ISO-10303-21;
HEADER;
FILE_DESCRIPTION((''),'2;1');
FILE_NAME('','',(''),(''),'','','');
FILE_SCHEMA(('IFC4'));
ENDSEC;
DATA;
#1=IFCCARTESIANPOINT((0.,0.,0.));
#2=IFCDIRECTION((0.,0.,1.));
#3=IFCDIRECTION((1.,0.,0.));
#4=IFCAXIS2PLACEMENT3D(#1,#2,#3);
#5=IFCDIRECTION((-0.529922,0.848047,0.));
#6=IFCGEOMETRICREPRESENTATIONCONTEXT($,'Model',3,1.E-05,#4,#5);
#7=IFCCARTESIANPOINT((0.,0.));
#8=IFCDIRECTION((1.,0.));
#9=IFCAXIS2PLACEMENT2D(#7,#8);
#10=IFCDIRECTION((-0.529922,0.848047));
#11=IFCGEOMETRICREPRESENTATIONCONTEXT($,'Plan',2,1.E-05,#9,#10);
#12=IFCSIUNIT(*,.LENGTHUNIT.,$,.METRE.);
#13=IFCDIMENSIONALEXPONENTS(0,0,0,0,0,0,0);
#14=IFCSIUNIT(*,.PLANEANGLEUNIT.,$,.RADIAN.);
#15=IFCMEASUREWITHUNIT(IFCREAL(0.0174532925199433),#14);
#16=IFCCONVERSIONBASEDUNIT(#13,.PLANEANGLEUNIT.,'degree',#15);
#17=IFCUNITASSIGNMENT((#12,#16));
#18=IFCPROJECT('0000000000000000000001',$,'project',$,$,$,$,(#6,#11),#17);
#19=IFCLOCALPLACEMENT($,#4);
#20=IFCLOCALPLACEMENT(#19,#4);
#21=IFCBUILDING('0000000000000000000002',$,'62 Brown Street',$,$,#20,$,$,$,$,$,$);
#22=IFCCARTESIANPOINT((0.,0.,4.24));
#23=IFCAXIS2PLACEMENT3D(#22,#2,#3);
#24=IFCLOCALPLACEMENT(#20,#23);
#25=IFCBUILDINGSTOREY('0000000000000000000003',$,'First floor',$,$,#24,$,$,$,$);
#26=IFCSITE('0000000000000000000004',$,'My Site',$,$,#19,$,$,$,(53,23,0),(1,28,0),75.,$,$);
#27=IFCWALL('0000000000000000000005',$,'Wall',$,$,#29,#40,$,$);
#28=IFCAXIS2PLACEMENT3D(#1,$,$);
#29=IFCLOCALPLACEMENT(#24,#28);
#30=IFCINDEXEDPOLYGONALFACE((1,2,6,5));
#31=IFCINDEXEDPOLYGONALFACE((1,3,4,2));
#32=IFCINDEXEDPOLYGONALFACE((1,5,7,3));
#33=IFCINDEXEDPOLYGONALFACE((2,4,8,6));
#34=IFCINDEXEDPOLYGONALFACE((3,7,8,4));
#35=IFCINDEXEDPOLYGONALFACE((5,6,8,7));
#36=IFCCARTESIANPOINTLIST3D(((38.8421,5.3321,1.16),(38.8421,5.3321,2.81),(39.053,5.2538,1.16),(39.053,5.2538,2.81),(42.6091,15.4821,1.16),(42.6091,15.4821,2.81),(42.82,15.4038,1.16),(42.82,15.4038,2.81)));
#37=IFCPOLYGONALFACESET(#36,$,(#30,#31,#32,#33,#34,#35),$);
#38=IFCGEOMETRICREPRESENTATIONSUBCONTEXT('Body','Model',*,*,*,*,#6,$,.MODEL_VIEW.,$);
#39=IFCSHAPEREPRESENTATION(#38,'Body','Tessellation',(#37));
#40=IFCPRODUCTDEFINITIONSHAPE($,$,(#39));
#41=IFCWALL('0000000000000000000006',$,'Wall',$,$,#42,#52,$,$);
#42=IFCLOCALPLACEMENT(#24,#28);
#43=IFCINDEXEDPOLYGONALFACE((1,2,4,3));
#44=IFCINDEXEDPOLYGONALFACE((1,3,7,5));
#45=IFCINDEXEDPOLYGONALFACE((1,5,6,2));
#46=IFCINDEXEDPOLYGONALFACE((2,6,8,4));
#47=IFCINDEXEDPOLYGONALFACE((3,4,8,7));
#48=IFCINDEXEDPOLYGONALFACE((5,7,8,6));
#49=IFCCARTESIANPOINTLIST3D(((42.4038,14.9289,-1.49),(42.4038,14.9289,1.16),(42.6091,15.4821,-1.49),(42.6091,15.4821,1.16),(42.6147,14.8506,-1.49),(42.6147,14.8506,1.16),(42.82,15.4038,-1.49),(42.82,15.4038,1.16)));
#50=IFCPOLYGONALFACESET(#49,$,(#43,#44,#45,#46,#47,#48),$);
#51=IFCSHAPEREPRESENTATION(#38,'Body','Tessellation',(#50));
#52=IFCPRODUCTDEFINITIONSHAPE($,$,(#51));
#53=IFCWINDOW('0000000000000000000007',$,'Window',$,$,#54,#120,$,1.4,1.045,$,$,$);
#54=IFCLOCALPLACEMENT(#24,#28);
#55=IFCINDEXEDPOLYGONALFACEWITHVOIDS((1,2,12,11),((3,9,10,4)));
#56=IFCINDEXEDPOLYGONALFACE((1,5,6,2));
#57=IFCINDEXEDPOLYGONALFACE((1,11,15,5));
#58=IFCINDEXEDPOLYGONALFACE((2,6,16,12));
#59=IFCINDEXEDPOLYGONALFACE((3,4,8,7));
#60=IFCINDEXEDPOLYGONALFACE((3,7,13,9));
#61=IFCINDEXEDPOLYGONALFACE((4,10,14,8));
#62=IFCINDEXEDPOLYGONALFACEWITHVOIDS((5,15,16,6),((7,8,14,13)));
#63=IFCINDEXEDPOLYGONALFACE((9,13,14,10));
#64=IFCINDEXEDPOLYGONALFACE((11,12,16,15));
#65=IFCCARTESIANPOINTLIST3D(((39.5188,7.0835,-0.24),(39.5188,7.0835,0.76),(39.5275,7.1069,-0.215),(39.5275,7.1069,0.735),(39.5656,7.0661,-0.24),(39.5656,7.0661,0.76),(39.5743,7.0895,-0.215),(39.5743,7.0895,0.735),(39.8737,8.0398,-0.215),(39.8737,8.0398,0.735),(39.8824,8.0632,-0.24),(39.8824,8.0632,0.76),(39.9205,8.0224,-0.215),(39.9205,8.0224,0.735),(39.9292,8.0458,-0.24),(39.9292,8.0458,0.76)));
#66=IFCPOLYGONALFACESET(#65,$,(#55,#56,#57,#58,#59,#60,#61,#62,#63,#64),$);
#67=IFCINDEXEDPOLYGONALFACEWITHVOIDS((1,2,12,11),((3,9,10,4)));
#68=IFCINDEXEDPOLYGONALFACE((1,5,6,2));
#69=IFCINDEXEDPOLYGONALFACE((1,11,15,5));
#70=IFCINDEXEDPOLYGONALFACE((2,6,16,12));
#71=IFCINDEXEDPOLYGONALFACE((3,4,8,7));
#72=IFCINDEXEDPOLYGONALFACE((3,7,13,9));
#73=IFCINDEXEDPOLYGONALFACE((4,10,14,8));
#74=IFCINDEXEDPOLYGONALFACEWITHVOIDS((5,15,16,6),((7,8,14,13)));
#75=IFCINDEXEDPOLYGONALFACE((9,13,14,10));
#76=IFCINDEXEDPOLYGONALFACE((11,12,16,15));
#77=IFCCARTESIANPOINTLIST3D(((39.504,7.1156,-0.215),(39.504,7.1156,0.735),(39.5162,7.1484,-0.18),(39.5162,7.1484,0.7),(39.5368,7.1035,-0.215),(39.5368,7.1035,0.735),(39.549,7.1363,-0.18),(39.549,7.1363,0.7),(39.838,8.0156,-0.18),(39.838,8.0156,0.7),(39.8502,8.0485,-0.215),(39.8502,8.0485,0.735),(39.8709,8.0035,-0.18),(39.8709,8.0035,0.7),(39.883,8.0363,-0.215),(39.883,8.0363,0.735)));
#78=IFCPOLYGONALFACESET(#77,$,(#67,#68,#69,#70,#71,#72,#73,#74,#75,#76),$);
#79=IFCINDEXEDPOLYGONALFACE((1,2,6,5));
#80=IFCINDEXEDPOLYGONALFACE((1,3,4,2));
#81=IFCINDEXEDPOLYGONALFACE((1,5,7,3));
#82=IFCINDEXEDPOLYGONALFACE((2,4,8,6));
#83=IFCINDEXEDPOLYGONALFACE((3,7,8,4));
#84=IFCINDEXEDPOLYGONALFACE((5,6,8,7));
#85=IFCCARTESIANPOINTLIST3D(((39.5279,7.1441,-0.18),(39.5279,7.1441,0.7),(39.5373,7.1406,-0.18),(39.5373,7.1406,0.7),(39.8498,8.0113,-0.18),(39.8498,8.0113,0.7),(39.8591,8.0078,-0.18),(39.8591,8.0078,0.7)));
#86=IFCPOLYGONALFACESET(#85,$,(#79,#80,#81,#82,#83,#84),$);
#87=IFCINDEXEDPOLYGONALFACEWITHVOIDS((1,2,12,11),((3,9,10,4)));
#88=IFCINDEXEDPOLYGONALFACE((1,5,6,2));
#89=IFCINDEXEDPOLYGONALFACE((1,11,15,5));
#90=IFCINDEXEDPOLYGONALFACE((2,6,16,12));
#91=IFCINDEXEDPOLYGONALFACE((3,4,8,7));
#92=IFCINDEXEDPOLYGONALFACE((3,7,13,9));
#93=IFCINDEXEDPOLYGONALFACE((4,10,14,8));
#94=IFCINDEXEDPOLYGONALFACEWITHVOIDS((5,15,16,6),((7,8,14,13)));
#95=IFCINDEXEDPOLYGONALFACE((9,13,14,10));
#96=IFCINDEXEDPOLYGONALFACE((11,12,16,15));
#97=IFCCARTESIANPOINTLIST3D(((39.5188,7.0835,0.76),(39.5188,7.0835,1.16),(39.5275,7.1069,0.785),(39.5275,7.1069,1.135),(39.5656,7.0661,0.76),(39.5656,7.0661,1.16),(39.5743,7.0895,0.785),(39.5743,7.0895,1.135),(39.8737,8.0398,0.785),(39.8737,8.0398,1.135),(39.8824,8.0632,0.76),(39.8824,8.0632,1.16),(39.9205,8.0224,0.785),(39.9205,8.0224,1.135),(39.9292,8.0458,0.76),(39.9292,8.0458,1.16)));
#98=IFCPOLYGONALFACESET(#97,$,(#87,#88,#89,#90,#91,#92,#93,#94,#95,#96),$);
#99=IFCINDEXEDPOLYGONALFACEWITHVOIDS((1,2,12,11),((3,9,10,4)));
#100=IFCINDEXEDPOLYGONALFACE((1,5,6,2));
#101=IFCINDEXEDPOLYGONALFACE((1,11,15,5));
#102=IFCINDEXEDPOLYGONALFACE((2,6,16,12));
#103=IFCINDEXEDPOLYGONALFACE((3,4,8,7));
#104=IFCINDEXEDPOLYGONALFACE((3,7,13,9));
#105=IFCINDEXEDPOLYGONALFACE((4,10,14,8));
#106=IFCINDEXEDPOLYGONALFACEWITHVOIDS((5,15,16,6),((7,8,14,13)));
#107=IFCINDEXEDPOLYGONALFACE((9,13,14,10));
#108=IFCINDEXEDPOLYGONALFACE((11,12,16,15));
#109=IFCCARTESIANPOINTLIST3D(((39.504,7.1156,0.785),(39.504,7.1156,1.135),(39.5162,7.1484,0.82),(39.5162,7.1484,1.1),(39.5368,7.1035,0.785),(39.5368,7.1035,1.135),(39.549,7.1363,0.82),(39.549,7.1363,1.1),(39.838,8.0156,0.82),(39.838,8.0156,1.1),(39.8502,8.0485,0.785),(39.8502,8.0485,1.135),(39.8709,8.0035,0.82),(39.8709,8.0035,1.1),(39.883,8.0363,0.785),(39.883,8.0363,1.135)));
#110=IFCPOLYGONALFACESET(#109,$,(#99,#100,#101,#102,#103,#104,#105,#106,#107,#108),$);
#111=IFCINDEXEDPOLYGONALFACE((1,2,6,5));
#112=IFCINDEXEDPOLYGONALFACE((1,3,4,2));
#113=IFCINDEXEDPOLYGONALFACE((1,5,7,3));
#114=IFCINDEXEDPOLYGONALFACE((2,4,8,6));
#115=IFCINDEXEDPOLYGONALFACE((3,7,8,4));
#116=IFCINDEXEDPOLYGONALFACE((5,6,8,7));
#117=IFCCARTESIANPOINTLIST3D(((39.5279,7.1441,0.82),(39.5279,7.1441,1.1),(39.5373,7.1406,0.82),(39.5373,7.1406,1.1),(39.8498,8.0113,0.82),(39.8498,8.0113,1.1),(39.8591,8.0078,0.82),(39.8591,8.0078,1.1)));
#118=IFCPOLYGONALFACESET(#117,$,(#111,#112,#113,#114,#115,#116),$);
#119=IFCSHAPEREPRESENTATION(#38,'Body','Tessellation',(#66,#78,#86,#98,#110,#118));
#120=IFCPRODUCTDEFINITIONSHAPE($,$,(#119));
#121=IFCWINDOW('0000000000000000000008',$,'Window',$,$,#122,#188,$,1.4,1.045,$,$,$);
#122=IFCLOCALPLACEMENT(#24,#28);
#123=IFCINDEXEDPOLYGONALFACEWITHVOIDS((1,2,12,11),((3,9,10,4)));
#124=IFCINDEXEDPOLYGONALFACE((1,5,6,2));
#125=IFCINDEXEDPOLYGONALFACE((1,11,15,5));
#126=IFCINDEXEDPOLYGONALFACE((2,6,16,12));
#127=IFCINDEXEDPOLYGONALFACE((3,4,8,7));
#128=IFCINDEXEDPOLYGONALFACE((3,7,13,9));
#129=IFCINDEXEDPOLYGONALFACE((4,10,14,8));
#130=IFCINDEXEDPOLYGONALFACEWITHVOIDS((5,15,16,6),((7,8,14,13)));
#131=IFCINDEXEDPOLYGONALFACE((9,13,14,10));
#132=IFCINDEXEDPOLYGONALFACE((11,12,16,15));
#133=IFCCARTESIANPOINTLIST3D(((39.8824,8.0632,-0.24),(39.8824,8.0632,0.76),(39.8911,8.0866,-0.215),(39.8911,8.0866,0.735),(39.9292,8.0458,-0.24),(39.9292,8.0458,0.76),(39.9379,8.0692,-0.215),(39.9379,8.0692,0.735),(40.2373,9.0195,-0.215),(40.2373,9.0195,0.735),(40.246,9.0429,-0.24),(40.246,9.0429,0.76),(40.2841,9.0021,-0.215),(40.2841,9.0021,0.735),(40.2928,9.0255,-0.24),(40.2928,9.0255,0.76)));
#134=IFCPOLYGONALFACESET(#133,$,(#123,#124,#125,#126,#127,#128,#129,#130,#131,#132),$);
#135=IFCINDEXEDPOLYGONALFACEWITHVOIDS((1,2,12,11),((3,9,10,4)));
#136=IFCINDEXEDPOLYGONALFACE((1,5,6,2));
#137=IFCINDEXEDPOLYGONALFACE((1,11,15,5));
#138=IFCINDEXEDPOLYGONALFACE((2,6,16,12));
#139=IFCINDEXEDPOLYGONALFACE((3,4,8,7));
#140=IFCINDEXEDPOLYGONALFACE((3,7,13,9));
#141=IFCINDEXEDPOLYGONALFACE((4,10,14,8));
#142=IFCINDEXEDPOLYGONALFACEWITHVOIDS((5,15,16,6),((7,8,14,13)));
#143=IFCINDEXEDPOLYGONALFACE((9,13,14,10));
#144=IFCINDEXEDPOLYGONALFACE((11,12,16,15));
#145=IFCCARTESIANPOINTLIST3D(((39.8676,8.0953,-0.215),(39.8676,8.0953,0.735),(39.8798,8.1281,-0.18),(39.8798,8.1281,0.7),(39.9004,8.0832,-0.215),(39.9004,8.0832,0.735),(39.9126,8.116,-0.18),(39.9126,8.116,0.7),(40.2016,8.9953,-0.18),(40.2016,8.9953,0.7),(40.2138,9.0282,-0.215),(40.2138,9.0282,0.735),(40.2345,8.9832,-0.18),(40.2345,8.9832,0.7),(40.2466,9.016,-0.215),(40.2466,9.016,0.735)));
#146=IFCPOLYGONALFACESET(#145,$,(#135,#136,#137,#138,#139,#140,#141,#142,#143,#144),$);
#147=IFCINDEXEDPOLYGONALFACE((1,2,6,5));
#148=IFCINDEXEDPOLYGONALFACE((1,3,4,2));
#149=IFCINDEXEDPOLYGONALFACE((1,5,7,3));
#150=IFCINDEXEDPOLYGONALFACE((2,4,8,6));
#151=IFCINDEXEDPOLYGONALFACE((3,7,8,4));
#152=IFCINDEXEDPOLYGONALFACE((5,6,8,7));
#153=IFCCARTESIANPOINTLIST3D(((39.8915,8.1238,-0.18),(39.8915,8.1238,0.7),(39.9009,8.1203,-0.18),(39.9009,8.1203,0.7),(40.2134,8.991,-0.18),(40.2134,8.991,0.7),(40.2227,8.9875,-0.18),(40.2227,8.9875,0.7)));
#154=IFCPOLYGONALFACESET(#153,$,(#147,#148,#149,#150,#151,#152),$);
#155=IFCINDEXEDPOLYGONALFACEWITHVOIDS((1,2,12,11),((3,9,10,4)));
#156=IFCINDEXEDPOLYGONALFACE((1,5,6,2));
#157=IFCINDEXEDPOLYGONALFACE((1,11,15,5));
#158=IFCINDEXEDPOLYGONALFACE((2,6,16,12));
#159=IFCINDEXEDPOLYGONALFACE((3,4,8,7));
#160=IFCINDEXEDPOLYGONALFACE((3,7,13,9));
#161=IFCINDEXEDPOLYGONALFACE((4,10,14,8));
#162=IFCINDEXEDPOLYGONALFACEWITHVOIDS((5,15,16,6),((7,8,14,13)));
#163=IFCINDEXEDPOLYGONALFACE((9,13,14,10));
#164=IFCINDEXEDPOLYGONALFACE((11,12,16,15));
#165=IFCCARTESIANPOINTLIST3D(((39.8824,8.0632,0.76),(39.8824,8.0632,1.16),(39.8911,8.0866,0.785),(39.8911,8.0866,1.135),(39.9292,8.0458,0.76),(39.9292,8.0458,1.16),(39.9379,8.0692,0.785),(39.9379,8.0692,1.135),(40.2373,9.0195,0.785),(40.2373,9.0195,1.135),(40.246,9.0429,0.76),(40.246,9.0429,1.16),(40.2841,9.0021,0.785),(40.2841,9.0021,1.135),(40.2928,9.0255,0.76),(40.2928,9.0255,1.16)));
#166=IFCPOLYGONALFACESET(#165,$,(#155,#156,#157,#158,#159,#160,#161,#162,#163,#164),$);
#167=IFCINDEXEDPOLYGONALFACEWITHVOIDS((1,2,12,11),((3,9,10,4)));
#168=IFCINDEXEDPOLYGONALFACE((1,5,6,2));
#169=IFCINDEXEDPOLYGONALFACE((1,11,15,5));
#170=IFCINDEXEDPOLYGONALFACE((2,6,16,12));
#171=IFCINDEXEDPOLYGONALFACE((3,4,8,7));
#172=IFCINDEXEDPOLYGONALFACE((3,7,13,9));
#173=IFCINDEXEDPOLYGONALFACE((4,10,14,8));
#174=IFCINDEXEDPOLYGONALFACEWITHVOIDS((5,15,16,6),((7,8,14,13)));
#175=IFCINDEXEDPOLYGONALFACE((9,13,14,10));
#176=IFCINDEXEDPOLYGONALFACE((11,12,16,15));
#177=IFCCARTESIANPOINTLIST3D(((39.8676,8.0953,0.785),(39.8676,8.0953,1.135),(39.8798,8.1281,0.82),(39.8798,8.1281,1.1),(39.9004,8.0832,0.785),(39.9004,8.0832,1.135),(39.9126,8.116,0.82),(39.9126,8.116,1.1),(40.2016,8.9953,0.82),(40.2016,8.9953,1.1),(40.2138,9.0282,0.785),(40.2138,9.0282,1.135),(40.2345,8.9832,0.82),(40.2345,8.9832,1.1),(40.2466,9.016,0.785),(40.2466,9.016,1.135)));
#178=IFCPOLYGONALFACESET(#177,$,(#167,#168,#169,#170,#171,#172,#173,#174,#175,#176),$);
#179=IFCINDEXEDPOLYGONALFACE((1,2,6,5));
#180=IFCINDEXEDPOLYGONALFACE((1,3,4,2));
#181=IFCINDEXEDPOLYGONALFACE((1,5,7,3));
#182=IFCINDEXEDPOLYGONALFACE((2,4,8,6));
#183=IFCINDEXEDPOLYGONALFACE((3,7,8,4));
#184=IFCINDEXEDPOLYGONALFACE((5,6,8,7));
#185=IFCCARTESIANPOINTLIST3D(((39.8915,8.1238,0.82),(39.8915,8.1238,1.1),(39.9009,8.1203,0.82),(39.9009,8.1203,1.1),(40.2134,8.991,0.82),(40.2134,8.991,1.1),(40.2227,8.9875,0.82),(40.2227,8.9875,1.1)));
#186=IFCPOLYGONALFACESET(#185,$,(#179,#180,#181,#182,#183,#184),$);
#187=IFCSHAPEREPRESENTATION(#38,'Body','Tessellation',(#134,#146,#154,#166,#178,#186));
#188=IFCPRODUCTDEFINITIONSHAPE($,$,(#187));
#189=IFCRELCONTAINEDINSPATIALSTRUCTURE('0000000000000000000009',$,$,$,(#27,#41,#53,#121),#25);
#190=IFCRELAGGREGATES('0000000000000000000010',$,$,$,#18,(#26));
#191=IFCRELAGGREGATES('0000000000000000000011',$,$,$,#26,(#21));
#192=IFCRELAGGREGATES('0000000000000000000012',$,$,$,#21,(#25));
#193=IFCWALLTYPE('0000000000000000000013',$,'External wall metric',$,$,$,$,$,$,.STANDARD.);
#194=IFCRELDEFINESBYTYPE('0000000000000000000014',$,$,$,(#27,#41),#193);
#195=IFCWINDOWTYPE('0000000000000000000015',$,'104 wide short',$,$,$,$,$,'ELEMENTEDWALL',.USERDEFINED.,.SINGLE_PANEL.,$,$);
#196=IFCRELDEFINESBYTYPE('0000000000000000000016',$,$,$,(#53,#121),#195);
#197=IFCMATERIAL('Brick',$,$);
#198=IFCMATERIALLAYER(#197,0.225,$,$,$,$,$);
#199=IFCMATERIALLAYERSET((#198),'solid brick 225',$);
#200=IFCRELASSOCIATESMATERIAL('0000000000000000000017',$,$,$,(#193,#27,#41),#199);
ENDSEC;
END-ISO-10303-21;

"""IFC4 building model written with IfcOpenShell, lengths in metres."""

from ifc_helpers import new_model, entity, si_unit, converted_unit, direction, frame, origin_with_axes, origin_2d_with_axis, place, context, subcontext, project, spatial, line, indexed_curve, outline, extrude, shape, source, transform, mapped, material, layer, layer_set, layer_usage, type_object, type_shapes, element, save


model = new_model("IFC4")

# Units and contexts
model_context = context("Model", 3, precision=1e-05, world=origin_with_axes(), true_north=direction((-0.529922, 0.848047, 0.0)))
plan_context = context("Plan", 2, precision=1e-05, world=origin_2d_with_axis(), true_north=direction((-0.529922, 0.848047)))
body_context_1 = subcontext(model_context, "Body", "Model", "MODEL_VIEW")
body_context_2 = subcontext(plan_context, "Body", "Plan", "PLAN_VIEW")
ifc_project = project(units=[si_unit("LENGTHUNIT", "METRE"), converted_unit("PLANEANGLEUNIT", "degree", entity("IfcReal", 0.0174532925199433), si_unit("PLANEANGLEUNIT", "RADIAN"), dimensions=[0, 0, 0, 0, 0, 0, 0])], contexts=[model_context, plan_context])

# Site, building, storey
site_placement = place(None, origin_with_axes())
site = spatial("IfcSite", under=ifc_project, at=site_placement, Name="My Site", RefLatitude=(53, 23, 0), RefLongitude=(1, 28, 0), RefElevation=75.0)
building_placement = place(site_placement, origin_with_axes())
building = spatial("IfcBuilding", under=site, at=building_placement, Name="62 Brown Street")
storey_placement = place(building_placement, frame((0.0, 0.0, 4.24), z_axis=(0.0, 0.0, 1.0), x_axis=(1.0, 0.0, 0.0)))
storey = spatial("IfcBuildingStorey", under=building, at=storey_placement, Name="First floor")

# Walls
ifc_material_1 = material(Name="Brick")
ifc_layer_1 = layer(ifc_material_1, 0.225)
ifc_layer_set_1 = layer_set([ifc_layer_1], Name="solid brick 225")
ifc_layer_usage_1 = layer_usage(ifc_layer_set_1, "AXIS2", "POSITIVE", 0.0)
wall_type_1 = type_object("IfcWallType", Name="External wall metric", PredefinedType="STANDARD", material=ifc_layer_set_1)
wall_1_placement = place(storey_placement, frame((39.053, 5.2538, 1.16), z_axis=(0.0, 0.0, 1.0), x_axis=(0.347944, 0.937515, 0.0)))
element("IfcWall", 1, at=wall_1_placement, inside=storey, type_object=wall_type_1, material=ifc_layer_usage_1, Name="Wall", context=body_context_1, shape_type="SweptSolid", body=[
    extrude(outline(indexed_curve([(0.0, 0.0), (0.0, 0.225), (10.8265, 0.225), (10.8265, 0.0), (0.0, 0.0)], self_intersect=False)), origin_with_axes(), (0.0, 0.0, 1.0), 1.65),
])
ifc_layer_usage_2 = layer_usage(ifc_layer_set_1, "AXIS2", "POSITIVE", 0.0)
wall_2_placement = place(storey_placement, frame((42.6147, 14.8506, -1.49), z_axis=(0.0, 0.0, 1.0), x_axis=(0.347944, 0.937515, 0.0)))
element("IfcWall", 2, at=wall_2_placement, inside=storey, type_object=wall_type_1, material=ifc_layer_usage_2, Name="Wall", context=body_context_1, shape_type="SweptSolid", body=[
    extrude(outline(indexed_curve([(0.0, 0.0), (0.0, 0.225), (0.5901, 0.225), (0.5901, 0.0), (0.0, 0.0)], self_intersect=False)), origin_with_axes(), (0.0, 0.0, 1.0), 2.65),
])

# Windows
window_type = type_object("IfcWindowType", Name="104 wide short", ElementType="ELEMENTEDWALL", PartitioningType="SINGLE_PANEL", PredefinedType="USERDEFINED")
shared_shape_1 = source(origin_with_axes(), body_context_1, "Body", "SweptSolid", [
    extrude(outline(indexed_curve([(0.0, 0.0), (1.045, 0.0), (1.045, 1.0), (0.0, 1.0)], segments=[line(1, 2, 3, 4, 1)]), holes=[indexed_curve([(0.025, 0.025), (1.02, 0.025), (1.02, 0.975), (0.025, 0.975)], segments=[line(1, 2, 3, 4, 1)])]), frame((0.0, 0.15, 0.0), z_axis=(0.0, -1.0, 0.0), x_axis=(1.0, 0.0, 0.0)), (0.0, 0.0, -1.0), 0.05),
    extrude(outline(indexed_curve([(0.0, 0.0), (0.995, 0.0), (0.995, 0.95), (0.0, 0.95)], segments=[line(1, 2, 3, 4, 1)]), holes=[indexed_curve([(0.035, 0.035), (0.96, 0.035), (0.96, 0.915), (0.035, 0.915)], segments=[line(1, 2, 3, 4, 1)])]), frame((0.025, 0.19, 0.025), z_axis=(0.0, -1.0, 0.0), x_axis=(1.0, 0.0, 0.0)), (0.0, 0.0, -1.0), 0.035),
    extrude(outline(indexed_curve([(0.035, 0.035), (0.96, 0.035), (0.96, 0.915), (0.035, 0.915)], segments=[line(1, 2, 3, 4, 1)])), frame((0.025, 0.2025, 0.025), z_axis=(0.0, -1.0, 0.0), x_axis=(1.0, 0.0, 0.0)), (0.0, 0.0, -1.0), 0.01),
    extrude(outline(indexed_curve([(0.0, 0.0), (1.045, 0.0), (1.045, 0.4), (0.0, 0.4)], segments=[line(1, 2, 3, 4, 1)]), holes=[indexed_curve([(0.025, 0.025), (1.02, 0.025), (1.02, 0.375), (0.025, 0.375)], segments=[line(1, 2, 3, 4, 1)])]), frame((0.0, 0.15, 1.0), z_axis=(0.0, -1.0, 0.0), x_axis=(1.0, 0.0, 0.0)), (0.0, 0.0, -1.0), 0.05),
    extrude(outline(indexed_curve([(0.0, 0.0), (0.995, 0.0), (0.995, 0.35), (0.0, 0.35)], segments=[line(1, 2, 3, 4, 1)]), holes=[indexed_curve([(0.035, 0.035), (0.96, 0.035), (0.96, 0.315), (0.035, 0.315)], segments=[line(1, 2, 3, 4, 1)])]), frame((0.025, 0.19, 1.025), z_axis=(0.0, -1.0, 0.0), x_axis=(1.0, 0.0, 0.0)), (0.0, 0.0, -1.0), 0.035),
    extrude(outline(indexed_curve([(0.035, 0.035), (0.96, 0.035), (0.96, 0.315), (0.035, 0.315)], segments=[line(1, 2, 3, 4, 1)])), frame((0.025, 0.2025, 1.025), z_axis=(0.0, -1.0, 0.0), x_axis=(1.0, 0.0, 0.0)), (0.0, 0.0, -1.0), 0.01),
])
shared_shape_2 = source(origin_with_axes(), body_context_2, "Body", "Curve2D", [
    entity("IfcIndexedPolyCurve", entity("IfcCartesianPointList2D", [[0.025, 0.15], [1.02, 0.15]])),
    entity("IfcIndexedPolyCurve", entity("IfcCartesianPointList2D", [[0.0, 0.2], [0.025, 0.2], [0.025, 0.15], [0.0, 0.15]]), [entity("IfcLineIndex", [1, 2, 3, 4, 1])]),
    entity("IfcIndexedPolyCurve", entity("IfcCartesianPointList2D", [[1.045, 0.2], [1.02, 0.2], [1.02, 0.15], [1.045, 0.15]]), [entity("IfcLineIndex", [1, 2, 3, 4, 1])]),
    entity("IfcIndexedPolyCurve", entity("IfcCartesianPointList2D", [[0.025, 0.19], [0.06, 0.19], [0.06, 0.225], [0.025, 0.225]]), [entity("IfcLineIndex", [1, 2, 3, 4, 1])]),
    entity("IfcIndexedPolyCurve", entity("IfcCartesianPointList2D", [[1.02, 0.19], [0.985, 0.19], [0.985, 0.225], [1.02, 0.225]]), [entity("IfcLineIndex", [1, 2, 3, 4, 1])]),
    entity("IfcIndexedPolyCurve", entity("IfcCartesianPointList2D", [[0.06, 0.19], [0.985, 0.19]])),
    entity("IfcIndexedPolyCurve", entity("IfcCartesianPointList2D", [[0.06, 0.225], [0.985, 0.225]])),
    entity("IfcIndexedPolyCurve", entity("IfcCartesianPointList2D", [[0.06, 0.2075], [0.985, 0.2075]])),
])
type_shapes(window_type, [shared_shape_1, shared_shape_2])
for number, where, z_axis, x_axis, name in (
    (3, (39.7063, 7.0139, -0.24), (0.0, 0.0, 1.0), (0.347944, 0.937515, 0.0), "Window"),
    (4, (40.0699, 7.9936, -0.24), (0.0, 0.0, 1.0), (0.347944, 0.937515, 0.0), "Window"),
):
    element("IfcWindow", number, at=place(storey_placement, frame(where, z_axis=z_axis, x_axis=x_axis)), inside=storey, type_object=window_type, Name=name, OverallHeight=1.4, OverallWidth=1.045, shapes=[
        shape(body_context_1, "Body", "MappedRepresentation", [mapped(shared_shape_1, transform((0.0, 0.0, 0.0), x_axis=(1.0, 0.0, 0.0), y_axis=(0.0, 1.0, 0.0), z_axis=(0.0, 0.0, 1.0), scale=1.0))]),
        shape(body_context_2, "Body", "MappedRepresentation", [mapped(shared_shape_2, transform((0.0, 0.0, 0.0), x_axis=(1.0, 0.0, 0.0), y_axis=(0.0, 1.0, 0.0), z_axis=(0.0, 0.0, 1.0), scale=1.0))]),
    ])

save(model, "model.ifc")
